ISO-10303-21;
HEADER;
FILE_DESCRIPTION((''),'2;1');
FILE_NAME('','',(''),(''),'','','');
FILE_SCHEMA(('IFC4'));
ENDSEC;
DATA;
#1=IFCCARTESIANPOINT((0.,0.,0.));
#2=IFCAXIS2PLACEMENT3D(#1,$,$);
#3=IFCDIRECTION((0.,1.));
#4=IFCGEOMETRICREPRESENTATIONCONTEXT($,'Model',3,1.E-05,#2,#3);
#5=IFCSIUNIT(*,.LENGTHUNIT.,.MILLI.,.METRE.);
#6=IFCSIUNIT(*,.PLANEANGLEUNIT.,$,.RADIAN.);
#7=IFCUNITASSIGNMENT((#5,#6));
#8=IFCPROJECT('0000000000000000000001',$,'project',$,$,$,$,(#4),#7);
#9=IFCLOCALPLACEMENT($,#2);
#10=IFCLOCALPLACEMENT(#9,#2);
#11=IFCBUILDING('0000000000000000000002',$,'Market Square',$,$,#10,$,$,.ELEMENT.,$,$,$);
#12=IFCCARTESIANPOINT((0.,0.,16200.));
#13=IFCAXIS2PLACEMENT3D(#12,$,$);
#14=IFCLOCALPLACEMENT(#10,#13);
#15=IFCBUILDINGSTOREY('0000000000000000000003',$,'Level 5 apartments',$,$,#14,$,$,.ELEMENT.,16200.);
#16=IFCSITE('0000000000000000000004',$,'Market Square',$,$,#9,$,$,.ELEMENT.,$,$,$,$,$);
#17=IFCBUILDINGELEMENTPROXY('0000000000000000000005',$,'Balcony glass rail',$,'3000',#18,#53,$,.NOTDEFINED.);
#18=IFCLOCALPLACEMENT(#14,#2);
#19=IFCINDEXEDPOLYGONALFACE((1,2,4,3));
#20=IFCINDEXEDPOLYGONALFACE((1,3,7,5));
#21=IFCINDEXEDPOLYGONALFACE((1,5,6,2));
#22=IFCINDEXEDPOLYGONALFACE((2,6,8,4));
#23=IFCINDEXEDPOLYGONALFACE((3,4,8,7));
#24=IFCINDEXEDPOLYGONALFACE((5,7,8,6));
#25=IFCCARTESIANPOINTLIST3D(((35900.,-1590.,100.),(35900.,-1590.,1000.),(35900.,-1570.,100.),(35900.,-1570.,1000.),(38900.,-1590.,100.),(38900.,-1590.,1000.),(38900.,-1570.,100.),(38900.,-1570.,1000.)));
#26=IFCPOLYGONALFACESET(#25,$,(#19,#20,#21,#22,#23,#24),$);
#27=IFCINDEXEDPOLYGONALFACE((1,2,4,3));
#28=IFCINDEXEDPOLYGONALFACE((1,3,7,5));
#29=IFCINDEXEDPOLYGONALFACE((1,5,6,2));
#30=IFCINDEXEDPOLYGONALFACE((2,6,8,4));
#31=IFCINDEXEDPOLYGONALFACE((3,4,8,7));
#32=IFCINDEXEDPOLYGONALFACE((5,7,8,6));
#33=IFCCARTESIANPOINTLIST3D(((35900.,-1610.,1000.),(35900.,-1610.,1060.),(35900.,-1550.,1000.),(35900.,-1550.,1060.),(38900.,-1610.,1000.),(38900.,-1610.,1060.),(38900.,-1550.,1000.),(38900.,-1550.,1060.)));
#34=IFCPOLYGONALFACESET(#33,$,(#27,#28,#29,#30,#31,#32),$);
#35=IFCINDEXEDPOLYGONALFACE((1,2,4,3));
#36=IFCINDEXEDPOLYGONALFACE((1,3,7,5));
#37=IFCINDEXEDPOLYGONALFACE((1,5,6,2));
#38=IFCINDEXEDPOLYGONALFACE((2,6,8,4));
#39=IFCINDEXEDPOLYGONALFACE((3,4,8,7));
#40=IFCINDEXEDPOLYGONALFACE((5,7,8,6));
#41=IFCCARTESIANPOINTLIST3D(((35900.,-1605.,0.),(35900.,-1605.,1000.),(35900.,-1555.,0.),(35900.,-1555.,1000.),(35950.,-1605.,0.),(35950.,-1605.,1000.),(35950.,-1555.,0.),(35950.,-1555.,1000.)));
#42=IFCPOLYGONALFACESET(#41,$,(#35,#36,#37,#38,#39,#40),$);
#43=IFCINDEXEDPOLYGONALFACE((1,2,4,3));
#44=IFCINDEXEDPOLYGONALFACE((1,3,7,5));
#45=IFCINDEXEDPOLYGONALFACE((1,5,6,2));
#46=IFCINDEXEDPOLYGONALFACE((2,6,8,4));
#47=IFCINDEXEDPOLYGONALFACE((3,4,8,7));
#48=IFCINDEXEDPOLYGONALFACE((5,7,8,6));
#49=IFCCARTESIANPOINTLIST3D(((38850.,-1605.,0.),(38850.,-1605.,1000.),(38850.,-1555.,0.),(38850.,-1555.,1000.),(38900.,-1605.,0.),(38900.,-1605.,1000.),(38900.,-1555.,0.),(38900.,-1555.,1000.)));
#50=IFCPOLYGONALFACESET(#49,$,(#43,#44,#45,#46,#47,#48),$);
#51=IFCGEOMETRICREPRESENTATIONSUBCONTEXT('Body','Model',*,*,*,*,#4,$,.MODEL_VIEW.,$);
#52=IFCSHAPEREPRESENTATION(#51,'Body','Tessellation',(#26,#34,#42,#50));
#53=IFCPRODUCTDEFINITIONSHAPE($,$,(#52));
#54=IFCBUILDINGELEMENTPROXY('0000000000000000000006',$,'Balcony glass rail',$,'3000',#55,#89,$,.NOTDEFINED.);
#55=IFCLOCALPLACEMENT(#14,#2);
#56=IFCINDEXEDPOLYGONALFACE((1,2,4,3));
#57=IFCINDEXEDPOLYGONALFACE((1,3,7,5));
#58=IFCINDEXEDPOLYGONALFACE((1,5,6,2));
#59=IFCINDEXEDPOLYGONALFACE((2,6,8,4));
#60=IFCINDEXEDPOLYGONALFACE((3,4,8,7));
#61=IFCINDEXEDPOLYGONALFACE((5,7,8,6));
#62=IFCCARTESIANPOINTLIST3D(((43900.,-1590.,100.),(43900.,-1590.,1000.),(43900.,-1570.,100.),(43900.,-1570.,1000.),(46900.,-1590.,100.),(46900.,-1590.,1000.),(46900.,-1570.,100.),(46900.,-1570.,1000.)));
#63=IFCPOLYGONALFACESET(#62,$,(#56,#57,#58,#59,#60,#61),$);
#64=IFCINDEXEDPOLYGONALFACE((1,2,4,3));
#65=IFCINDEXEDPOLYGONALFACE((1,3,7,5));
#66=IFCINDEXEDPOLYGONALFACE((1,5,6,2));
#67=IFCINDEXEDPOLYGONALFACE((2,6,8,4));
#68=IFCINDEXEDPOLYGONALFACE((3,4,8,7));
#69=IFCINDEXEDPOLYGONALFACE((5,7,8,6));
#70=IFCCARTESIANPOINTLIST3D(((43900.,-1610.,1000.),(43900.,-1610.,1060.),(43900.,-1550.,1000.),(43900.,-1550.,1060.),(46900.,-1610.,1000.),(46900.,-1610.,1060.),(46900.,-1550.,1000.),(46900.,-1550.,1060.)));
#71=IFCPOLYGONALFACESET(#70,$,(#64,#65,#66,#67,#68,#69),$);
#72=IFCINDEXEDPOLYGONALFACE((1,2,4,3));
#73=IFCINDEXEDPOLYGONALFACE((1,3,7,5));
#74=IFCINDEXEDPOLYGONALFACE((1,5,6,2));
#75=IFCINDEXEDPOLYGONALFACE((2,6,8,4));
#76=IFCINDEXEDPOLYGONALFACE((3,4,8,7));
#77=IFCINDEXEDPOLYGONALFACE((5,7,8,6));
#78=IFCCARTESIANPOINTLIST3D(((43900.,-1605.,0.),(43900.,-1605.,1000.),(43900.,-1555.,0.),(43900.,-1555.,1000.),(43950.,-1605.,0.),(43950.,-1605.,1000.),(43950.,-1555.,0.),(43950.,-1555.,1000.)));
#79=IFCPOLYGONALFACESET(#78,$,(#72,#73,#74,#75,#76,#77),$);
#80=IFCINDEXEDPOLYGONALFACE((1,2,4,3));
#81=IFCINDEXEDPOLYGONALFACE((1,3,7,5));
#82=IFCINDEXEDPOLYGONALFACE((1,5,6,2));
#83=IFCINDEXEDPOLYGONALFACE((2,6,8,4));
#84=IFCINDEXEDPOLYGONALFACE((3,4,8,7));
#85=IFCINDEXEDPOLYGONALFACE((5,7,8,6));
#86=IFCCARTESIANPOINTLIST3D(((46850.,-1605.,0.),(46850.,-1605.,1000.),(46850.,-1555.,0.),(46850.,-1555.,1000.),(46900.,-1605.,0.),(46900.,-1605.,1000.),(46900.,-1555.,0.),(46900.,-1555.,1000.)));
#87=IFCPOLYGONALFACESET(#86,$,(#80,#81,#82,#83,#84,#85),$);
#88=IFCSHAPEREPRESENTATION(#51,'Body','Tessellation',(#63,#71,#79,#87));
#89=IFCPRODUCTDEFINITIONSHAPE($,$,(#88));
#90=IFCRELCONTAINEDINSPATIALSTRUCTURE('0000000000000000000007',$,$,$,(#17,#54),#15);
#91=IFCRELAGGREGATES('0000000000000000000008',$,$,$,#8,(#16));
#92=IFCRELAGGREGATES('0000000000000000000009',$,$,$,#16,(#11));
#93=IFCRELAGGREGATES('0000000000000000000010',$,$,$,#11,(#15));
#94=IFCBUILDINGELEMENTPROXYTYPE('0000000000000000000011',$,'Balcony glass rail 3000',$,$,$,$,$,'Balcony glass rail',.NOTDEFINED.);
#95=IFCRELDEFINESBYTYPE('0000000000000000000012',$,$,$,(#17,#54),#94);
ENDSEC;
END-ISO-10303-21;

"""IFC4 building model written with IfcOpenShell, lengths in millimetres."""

from ifc_helpers import new_model, si_unit, direction, frame, origin, place, context, subcontext, project, spatial, polyline, outline, extrude, source, transform, mapped, type_object, type_shapes, element, save


model = new_model("IFC4")

# Units and contexts
model_context = context("Model", 3, precision=1e-05, world=origin(), true_north=direction((0.0, 1.0)))
body_context = subcontext(model_context, "Body", "Model", "MODEL_VIEW")
ifc_project = project(units=[si_unit("LENGTHUNIT", "METRE", prefix="MILLI"), si_unit("PLANEANGLEUNIT", "RADIAN")], contexts=[model_context])

# Site, building, storey
site_placement = place(None, origin())
site = spatial("IfcSite", under=ifc_project, at=site_placement, Name="Market Square", CompositionType="ELEMENT")
building_placement = place(site_placement, origin())
building = spatial("IfcBuilding", under=site, at=building_placement, Name="Market Square", CompositionType="ELEMENT")
storey_placement = place(building_placement, frame((0.0, 0.0, 16200.0)))
storey = spatial("IfcBuildingStorey", under=building, at=storey_placement, Name="Level 5 apartments", CompositionType="ELEMENT", Elevation=16200.0)

# Building element proxies
building_element_proxy_type = type_object("IfcBuildingElementProxyType", Name="Balcony glass rail 3000", ElementType="Balcony glass rail", PredefinedType="NOTDEFINED")
shared_shape = source(origin(), body_context, "Body", "SweptSolid", [
    extrude(outline(polyline([(0.0, -10.0), (3000.0, -10.0), (3000.0, 10.0), (0.0, 10.0), (0.0, -10.0)])), frame((0.0, 0.0, 100.0)), (0.0, 0.0, 1.0), 900.0),
    extrude(outline(polyline([(0.0, -30.0), (3000.0, -30.0), (3000.0, 30.0), (0.0, 30.0), (0.0, -30.0)])), frame((0.0, 0.0, 1000.0)), (0.0, 0.0, 1.0), 60.0),
    extrude(outline(polyline([(0.0, -25.0), (50.0, -25.0), (50.0, 25.0), (0.0, 25.0), (0.0, -25.0)])), origin(), (0.0, 0.0, 1.0), 1000.0),
    extrude(outline(polyline([(2950.0, -25.0), (3000.0, -25.0), (3000.0, 25.0), (2950.0, 25.0), (2950.0, -25.0)])), origin(), (0.0, 0.0, 1.0), 1000.0),
])
type_shapes(building_element_proxy_type, [shared_shape])
for number, where, z_axis, x_axis, name in (
    (1, (35900.0, -1580.0, 0.0), (0.0, 0.0, 1.0), (1.0, 0.0, 0.0), "Balcony glass rail"),
    (2, (43900.0, -1580.0, 0.0), (0.0, 0.0, 1.0), (1.0, 0.0, 0.0), "Balcony glass rail"),
):
    element("IfcBuildingElementProxy", number, at=place(storey_placement, frame(where, z_axis=z_axis, x_axis=x_axis)), inside=storey, type_object=building_element_proxy_type, Name=name, ObjectType="3000", PredefinedType="NOTDEFINED", context=body_context, shape_type="MappedRepresentation", body=[
        mapped(shared_shape, transform((0.0, 0.0, 0.0))),
    ])

save(model, "model.ifc")
